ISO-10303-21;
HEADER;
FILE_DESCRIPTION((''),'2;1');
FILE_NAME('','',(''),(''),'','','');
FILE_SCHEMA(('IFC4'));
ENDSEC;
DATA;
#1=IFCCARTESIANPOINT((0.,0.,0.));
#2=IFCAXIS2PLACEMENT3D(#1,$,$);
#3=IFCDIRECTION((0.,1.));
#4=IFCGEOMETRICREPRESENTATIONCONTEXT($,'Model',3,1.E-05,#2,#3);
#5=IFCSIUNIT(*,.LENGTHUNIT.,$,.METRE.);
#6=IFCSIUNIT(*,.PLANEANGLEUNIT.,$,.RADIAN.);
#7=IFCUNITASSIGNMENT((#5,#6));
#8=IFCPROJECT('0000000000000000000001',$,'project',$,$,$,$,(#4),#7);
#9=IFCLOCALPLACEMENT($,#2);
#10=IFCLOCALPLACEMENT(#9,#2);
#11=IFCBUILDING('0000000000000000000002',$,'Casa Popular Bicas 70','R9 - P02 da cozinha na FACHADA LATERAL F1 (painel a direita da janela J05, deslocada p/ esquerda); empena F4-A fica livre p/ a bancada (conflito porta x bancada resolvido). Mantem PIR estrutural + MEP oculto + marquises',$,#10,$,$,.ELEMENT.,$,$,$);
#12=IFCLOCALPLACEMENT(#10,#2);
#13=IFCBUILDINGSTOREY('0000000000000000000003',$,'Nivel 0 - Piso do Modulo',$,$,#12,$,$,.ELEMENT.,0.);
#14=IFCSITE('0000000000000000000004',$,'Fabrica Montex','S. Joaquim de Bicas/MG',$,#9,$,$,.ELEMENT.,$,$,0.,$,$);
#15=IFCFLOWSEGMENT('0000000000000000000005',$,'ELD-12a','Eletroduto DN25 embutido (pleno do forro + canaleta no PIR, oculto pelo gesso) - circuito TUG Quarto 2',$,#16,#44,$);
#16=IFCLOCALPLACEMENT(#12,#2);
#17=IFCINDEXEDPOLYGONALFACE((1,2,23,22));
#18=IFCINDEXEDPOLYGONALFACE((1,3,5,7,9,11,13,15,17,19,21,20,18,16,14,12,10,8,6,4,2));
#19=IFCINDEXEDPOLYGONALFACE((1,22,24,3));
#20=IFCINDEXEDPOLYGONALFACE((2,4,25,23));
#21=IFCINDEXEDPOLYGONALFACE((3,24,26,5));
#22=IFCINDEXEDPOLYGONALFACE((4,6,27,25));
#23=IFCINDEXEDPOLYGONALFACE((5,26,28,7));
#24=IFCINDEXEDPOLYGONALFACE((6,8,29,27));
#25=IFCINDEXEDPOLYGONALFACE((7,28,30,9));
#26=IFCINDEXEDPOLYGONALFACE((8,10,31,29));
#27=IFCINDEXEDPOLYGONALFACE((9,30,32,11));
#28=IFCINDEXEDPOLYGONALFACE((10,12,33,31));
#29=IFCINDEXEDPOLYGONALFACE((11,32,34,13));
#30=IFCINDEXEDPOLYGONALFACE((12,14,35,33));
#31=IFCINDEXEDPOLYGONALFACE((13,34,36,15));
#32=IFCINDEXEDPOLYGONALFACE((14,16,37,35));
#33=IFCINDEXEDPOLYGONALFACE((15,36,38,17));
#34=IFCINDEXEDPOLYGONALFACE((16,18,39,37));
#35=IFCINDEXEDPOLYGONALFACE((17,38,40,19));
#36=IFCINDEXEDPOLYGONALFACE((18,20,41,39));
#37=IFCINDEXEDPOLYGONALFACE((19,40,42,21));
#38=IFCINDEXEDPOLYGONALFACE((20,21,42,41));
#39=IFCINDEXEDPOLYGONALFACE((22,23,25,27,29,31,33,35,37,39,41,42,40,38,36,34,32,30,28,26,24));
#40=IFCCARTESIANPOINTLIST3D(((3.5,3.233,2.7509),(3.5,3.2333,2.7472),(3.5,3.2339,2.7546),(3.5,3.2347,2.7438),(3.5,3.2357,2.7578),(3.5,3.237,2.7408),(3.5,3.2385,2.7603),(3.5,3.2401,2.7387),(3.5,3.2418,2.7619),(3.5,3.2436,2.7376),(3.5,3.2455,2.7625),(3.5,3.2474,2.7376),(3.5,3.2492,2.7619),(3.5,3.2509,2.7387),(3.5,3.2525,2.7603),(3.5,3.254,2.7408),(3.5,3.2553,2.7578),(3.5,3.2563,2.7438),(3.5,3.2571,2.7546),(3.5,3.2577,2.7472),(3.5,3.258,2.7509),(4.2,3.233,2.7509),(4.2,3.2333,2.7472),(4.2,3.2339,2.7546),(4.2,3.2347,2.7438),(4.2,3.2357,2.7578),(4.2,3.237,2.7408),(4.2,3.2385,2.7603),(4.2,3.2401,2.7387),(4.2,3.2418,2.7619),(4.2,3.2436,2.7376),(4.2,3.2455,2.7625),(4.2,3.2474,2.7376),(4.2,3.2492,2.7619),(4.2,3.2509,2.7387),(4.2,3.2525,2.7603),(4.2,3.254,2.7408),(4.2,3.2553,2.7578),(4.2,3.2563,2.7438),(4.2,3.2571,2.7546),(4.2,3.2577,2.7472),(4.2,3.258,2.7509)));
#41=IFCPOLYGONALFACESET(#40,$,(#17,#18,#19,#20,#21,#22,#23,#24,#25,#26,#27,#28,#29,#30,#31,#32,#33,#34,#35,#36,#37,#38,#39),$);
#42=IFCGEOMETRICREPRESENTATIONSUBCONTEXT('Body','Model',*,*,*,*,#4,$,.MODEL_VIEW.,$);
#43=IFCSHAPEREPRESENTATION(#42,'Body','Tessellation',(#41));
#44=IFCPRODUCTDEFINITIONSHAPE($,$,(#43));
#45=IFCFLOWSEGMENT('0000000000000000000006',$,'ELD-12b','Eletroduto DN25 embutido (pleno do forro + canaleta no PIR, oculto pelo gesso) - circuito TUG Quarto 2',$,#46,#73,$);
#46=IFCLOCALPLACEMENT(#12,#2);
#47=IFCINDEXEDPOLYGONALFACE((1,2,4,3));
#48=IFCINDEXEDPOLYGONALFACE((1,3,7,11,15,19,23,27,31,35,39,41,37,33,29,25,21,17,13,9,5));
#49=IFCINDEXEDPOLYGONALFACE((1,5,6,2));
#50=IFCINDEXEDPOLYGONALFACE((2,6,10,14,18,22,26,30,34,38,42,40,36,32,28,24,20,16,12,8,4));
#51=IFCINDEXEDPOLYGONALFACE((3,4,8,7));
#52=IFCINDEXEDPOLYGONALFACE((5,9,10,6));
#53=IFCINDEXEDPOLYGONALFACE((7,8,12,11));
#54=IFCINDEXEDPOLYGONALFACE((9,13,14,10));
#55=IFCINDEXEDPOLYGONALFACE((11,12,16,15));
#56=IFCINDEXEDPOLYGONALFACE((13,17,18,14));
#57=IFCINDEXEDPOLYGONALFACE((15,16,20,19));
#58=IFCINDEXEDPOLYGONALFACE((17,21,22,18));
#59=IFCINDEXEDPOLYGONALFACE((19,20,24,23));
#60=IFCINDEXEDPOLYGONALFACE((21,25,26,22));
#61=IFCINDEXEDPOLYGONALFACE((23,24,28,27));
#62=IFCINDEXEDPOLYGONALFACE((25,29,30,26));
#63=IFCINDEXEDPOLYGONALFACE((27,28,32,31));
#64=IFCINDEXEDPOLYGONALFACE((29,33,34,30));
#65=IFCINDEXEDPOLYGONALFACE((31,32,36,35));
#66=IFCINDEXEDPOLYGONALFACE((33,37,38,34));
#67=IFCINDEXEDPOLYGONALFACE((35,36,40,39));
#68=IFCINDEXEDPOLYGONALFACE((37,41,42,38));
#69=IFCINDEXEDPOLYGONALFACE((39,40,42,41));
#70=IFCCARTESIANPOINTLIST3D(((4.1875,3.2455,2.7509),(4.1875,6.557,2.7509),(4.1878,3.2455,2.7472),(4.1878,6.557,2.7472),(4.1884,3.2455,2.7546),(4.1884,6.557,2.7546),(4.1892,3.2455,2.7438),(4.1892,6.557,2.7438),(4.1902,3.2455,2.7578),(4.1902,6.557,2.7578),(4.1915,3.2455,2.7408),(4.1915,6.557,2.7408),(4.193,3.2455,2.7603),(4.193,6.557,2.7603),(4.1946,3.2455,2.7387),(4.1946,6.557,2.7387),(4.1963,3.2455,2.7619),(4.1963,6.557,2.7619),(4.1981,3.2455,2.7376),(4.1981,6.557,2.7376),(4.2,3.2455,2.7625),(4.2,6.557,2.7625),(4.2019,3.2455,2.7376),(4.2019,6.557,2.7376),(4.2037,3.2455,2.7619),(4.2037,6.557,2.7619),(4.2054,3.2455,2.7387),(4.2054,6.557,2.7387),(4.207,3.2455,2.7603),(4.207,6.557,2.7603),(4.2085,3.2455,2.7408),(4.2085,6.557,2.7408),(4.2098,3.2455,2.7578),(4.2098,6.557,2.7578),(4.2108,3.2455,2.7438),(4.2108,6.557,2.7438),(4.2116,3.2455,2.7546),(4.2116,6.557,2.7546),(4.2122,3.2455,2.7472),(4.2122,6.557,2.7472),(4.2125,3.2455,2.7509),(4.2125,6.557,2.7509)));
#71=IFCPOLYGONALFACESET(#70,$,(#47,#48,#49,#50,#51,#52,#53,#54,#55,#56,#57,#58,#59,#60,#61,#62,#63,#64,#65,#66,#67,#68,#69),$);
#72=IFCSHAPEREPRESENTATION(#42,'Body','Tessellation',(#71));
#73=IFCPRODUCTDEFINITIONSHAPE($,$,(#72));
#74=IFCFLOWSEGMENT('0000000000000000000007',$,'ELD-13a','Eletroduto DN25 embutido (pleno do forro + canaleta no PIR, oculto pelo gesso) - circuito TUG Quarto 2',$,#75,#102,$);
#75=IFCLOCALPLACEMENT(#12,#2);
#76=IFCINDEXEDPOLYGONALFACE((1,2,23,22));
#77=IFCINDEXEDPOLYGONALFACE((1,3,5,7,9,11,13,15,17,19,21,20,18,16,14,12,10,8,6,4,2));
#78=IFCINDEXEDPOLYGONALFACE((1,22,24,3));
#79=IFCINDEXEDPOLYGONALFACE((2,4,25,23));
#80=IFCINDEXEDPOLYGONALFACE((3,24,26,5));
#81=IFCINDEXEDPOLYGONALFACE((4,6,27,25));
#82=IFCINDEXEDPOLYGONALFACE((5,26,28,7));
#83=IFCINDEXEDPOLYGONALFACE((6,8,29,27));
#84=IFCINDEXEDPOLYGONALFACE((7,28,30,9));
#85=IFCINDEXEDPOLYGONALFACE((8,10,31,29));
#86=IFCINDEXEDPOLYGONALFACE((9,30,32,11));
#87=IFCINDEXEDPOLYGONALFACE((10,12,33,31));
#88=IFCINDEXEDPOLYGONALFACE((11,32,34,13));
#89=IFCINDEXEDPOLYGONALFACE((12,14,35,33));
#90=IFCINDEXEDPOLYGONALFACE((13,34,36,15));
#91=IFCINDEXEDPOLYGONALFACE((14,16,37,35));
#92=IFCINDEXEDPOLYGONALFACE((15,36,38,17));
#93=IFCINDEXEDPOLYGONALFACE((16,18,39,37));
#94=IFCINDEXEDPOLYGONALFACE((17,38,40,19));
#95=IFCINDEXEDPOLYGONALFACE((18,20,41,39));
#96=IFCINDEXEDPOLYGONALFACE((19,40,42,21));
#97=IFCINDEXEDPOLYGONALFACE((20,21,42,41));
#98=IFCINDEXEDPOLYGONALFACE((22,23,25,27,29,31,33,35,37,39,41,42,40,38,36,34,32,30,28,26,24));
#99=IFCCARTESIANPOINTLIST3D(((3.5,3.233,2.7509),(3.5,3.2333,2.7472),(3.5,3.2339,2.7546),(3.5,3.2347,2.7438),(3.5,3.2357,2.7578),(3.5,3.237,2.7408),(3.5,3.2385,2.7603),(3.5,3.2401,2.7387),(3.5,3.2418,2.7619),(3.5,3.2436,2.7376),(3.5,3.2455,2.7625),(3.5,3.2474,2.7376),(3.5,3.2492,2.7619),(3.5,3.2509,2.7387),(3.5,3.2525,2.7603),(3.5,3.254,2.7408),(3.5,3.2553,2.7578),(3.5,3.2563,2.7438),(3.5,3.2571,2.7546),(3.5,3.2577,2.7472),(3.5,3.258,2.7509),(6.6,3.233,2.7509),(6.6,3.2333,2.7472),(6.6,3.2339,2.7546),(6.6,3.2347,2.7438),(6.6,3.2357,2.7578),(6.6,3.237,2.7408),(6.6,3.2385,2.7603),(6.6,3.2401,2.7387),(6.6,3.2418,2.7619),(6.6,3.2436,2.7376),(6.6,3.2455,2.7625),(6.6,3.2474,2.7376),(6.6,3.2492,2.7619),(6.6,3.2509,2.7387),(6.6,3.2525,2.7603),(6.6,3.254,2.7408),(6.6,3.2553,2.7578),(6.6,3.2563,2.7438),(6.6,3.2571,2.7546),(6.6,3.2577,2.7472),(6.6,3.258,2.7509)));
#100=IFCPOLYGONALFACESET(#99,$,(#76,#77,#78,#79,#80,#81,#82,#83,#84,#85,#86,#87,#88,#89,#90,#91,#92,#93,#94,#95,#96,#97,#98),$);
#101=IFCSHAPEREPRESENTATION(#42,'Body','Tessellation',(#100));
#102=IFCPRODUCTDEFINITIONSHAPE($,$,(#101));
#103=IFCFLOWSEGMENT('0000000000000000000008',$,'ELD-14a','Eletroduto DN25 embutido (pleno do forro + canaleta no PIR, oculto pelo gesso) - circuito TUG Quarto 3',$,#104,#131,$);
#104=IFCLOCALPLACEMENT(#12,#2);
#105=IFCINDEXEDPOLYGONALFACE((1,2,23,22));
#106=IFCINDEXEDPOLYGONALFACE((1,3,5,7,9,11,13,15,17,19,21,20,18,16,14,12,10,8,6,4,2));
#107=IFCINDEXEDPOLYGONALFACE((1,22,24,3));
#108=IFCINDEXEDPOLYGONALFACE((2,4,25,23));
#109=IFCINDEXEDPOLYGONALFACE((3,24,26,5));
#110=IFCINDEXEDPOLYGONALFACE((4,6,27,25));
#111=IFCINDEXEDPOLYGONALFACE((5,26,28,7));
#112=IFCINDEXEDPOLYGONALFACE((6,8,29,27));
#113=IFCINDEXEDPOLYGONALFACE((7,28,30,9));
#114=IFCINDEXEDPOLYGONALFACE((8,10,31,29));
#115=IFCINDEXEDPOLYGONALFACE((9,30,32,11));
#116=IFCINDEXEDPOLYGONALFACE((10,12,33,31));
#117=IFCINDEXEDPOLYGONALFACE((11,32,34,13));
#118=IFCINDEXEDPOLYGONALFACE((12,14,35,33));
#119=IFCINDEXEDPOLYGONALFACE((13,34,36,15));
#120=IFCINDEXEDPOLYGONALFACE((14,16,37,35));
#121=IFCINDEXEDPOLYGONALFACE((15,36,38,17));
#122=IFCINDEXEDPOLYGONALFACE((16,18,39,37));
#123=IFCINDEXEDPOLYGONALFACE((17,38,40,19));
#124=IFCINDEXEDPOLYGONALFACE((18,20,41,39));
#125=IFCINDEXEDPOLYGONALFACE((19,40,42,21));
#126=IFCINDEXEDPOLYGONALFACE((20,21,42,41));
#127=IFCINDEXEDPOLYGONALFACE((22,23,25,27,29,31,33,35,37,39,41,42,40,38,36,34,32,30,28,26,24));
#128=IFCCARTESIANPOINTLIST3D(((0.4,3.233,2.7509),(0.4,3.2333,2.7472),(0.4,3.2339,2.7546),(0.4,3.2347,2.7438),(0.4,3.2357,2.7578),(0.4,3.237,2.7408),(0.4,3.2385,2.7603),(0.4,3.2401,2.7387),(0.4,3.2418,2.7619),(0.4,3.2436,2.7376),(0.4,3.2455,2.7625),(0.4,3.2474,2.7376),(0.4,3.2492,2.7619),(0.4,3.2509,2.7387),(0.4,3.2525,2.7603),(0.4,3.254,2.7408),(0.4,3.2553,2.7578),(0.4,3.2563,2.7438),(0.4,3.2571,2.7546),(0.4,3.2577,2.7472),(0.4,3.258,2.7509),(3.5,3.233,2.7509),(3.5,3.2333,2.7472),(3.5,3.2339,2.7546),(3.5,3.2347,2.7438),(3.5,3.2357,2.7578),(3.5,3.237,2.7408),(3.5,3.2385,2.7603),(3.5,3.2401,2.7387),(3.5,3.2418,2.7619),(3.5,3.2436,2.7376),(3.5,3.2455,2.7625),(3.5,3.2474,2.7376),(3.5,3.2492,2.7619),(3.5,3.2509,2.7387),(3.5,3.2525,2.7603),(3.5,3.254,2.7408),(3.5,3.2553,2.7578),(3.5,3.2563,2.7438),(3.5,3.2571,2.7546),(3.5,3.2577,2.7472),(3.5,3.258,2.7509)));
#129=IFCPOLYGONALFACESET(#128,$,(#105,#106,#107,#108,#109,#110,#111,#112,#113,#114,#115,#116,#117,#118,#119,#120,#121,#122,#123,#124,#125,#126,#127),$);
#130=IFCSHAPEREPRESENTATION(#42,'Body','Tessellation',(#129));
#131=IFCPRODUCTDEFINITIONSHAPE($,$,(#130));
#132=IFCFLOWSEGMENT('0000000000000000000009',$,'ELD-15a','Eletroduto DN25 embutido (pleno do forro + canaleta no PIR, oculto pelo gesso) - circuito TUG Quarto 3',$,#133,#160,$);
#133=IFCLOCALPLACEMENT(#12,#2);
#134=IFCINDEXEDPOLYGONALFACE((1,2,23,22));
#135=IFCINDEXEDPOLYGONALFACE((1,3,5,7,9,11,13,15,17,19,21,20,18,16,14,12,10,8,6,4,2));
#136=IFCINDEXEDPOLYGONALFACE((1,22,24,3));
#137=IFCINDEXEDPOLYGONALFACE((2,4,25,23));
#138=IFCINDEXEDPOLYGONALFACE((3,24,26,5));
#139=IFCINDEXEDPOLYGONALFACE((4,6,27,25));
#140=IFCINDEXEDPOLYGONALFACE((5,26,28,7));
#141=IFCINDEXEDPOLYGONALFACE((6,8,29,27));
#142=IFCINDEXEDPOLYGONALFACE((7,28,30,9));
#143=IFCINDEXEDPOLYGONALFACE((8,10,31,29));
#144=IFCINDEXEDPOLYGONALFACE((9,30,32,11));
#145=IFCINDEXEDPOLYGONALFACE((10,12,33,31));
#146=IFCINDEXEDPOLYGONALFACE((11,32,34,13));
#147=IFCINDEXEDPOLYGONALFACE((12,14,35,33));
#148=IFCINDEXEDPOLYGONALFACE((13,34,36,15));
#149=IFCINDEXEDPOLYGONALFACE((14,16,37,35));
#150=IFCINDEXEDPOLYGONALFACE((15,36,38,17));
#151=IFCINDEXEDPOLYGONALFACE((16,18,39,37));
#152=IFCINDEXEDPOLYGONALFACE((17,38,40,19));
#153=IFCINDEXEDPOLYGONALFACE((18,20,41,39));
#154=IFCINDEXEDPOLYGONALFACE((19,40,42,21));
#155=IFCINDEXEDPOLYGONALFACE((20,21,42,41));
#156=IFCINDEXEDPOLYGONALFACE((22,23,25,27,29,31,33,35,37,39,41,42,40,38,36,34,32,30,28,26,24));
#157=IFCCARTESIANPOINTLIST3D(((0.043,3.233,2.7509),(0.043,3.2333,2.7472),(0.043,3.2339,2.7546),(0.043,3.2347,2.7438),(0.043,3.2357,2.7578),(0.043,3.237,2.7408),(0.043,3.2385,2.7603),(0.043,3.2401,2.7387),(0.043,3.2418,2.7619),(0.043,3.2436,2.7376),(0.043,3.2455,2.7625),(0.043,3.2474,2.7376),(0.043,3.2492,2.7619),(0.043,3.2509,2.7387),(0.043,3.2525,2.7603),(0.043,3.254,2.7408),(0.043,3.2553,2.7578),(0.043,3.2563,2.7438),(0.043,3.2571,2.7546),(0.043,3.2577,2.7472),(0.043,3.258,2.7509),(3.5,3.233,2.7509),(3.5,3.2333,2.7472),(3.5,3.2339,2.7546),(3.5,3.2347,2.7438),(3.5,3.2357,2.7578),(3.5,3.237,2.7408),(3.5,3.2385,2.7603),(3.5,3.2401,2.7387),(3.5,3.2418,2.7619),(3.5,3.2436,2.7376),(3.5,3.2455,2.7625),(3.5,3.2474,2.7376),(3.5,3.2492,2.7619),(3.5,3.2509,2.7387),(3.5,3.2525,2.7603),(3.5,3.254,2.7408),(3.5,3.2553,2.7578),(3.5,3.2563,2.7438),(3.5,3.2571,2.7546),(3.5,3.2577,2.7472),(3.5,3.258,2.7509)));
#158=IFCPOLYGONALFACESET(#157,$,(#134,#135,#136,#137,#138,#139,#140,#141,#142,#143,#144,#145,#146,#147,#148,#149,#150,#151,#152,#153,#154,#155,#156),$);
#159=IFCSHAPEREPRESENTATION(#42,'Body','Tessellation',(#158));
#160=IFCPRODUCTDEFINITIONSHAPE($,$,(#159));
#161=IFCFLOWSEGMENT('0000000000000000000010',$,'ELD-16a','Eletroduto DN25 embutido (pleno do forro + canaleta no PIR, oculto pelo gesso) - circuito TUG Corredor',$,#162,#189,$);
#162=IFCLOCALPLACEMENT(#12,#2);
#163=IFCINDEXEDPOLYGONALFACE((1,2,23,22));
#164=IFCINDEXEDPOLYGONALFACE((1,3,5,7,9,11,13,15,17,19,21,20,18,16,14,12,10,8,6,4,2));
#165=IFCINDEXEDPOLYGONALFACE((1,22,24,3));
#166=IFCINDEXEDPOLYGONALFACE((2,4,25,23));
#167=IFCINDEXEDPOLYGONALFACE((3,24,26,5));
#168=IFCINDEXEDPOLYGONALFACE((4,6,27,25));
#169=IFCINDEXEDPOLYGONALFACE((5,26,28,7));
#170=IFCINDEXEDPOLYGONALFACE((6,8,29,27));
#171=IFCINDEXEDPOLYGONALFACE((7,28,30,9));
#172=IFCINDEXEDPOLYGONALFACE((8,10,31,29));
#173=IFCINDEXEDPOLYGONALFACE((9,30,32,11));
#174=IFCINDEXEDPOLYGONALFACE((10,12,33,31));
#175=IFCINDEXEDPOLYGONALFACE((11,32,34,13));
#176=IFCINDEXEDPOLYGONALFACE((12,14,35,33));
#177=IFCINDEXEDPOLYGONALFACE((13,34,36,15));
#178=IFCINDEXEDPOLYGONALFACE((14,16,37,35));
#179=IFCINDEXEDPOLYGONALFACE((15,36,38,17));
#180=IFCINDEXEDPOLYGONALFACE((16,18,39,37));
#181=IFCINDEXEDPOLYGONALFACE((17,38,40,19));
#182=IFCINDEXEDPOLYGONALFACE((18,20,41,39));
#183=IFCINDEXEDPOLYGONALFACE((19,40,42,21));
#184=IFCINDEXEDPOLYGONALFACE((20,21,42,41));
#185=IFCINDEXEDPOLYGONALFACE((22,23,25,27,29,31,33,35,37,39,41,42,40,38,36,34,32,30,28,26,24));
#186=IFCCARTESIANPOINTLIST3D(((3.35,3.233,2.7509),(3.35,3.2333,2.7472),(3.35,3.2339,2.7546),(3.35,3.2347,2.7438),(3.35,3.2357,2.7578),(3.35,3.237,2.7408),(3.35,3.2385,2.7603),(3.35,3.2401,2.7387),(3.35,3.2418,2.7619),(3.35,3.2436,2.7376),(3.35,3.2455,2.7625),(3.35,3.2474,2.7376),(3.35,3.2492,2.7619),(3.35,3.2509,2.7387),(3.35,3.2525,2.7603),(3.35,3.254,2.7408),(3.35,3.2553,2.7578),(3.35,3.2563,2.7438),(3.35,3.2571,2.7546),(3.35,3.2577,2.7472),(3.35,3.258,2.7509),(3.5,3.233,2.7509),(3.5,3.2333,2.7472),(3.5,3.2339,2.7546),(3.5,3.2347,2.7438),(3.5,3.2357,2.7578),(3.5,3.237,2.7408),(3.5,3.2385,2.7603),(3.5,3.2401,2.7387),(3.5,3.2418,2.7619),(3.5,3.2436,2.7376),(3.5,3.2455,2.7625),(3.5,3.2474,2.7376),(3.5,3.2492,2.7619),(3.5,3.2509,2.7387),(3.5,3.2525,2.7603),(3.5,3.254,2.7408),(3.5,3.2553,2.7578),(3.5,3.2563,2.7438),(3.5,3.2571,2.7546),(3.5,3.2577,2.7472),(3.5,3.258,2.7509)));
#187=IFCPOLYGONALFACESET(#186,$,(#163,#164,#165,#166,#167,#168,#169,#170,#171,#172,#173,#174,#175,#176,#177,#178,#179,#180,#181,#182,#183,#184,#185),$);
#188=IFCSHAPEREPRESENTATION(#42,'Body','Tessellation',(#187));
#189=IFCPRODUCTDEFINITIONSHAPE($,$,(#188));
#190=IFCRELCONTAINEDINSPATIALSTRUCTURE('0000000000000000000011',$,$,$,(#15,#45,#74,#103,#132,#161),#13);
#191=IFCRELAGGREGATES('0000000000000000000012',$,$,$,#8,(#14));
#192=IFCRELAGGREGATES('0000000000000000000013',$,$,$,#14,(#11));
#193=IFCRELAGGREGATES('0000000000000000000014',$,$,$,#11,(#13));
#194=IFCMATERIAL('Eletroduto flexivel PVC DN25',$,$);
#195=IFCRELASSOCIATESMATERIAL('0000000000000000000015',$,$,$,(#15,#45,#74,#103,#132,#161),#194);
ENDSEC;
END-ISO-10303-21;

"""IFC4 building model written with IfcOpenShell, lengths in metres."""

from ifc_helpers import new_model, si_unit, direction, frame, origin, origin_2d, place, context, subcontext, project, spatial, circle, extrude, material, element, save


model = new_model("IFC4")

# Units and contexts
model_context = context("Model", 3, precision=1e-05, world=origin(), true_north=direction((0.0, 1.0)))
body_context = subcontext(model_context, "Body", "Model", "MODEL_VIEW")
ifc_project = project(units=[si_unit("LENGTHUNIT", "METRE"), si_unit("PLANEANGLEUNIT", "RADIAN")], contexts=[model_context])

# Site, building, storey
site_placement = place(None, origin())
site = spatial("IfcSite", under=ifc_project, at=site_placement, Name="Fabrica Montex", Description="S. Joaquim de Bicas/MG", CompositionType="ELEMENT", RefElevation=0.0)
building_placement = place(site_placement, origin())
building = spatial("IfcBuilding", under=site, at=building_placement, Name="Casa Popular Bicas 70", Description="R9 - P02 da cozinha na FACHADA LATERAL F1 (painel a direita da janela J05, deslocada p/ esquerda); empena F4-A fica livre p/ a bancada (conflito porta x bancada resolvido). Mantem PIR estrutural + MEP oculto + marquises", CompositionType="ELEMENT")
storey_placement = place(building_placement, origin())
storey = spatial("IfcBuildingStorey", under=building, at=storey_placement, Name="Nivel 0 - Piso do Modulo", CompositionType="ELEMENT", Elevation=0.0)

# Flow segments
ifc_material_1 = material(Name="Eletroduto flexivel PVC DN25")
flow_segment_1_placement = place(storey_placement, frame((3.5, 3.2455, 2.75), z_axis=(1.0, 0.0, 0.0), x_axis=(0.0, 0.0, 1.0)))
element("IfcFlowSegment", 1, at=flow_segment_1_placement, inside=storey, material=ifc_material_1, Name="ELD-12a", Description="Eletroduto DN25 embutido (pleno do forro + canaleta no PIR, oculto pelo gesso) - circuito TUG Quarto 2", context=body_context, shape_type="SweptSolid", body=[
    extrude(circle(Radius=0.0125, at=origin_2d()), origin(), (0.0, 0.0, 1.0), 0.7),
])
flow_segment_2_placement = place(storey_placement, frame((4.2, 3.2455, 2.75), z_axis=(0.0, 1.0, 0.0), x_axis=(0.0, 0.0, 1.0)))
element("IfcFlowSegment", 2, at=flow_segment_2_placement, inside=storey, material=ifc_material_1, Name="ELD-12b", Description="Eletroduto DN25 embutido (pleno do forro + canaleta no PIR, oculto pelo gesso) - circuito TUG Quarto 2", context=body_context, shape_type="SweptSolid", body=[
    extrude(circle(Radius=0.0125, at=origin_2d()), origin(), (0.0, 0.0, 1.0), 3.3115),
])
flow_segment_3_placement = place(storey_placement, frame((3.5, 3.2455, 2.75), z_axis=(1.0, 0.0, 0.0), x_axis=(0.0, 0.0, 1.0)))
element("IfcFlowSegment", 3, at=flow_segment_3_placement, inside=storey, material=ifc_material_1, Name="ELD-13a", Description="Eletroduto DN25 embutido (pleno do forro + canaleta no PIR, oculto pelo gesso) - circuito TUG Quarto 2", context=body_context, shape_type="SweptSolid", body=[
    extrude(circle(Radius=0.0125, at=origin_2d()), origin(), (0.0, 0.0, 1.0), 3.1),
])
flow_segment_4_placement = place(storey_placement, frame((3.5, 3.2455, 2.75), z_axis=(-1.0, 0.0, 0.0), x_axis=(0.0, 0.0, 1.0)))
element("IfcFlowSegment", 4, at=flow_segment_4_placement, inside=storey, material=ifc_material_1, Name="ELD-14a", Description="Eletroduto DN25 embutido (pleno do forro + canaleta no PIR, oculto pelo gesso) - circuito TUG Quarto 3", context=body_context, shape_type="SweptSolid", body=[
    extrude(circle(Radius=0.0125, at=origin_2d()), origin(), (0.0, 0.0, 1.0), 3.1),
])
flow_segment_5_placement = place(storey_placement, frame((3.5, 3.2455, 2.75), z_axis=(-1.0, 0.0, 0.0), x_axis=(0.0, 0.0, 1.0)))
element("IfcFlowSegment", 5, at=flow_segment_5_placement, inside=storey, material=ifc_material_1, Name="ELD-15a", Description="Eletroduto DN25 embutido (pleno do forro + canaleta no PIR, oculto pelo gesso) - circuito TUG Quarto 3", context=body_context, shape_type="SweptSolid", body=[
    extrude(circle(Radius=0.0125, at=origin_2d()), origin(), (0.0, 0.0, 1.0), 3.457),
])
flow_segment_6_placement = place(storey_placement, frame((3.5, 3.2455, 2.75), z_axis=(-1.0, 0.0, 0.0), x_axis=(0.0, 0.0, 1.0)))
element("IfcFlowSegment", 6, at=flow_segment_6_placement, inside=storey, material=ifc_material_1, Name="ELD-16a", Description="Eletroduto DN25 embutido (pleno do forro + canaleta no PIR, oculto pelo gesso) - circuito TUG Corredor", context=body_context, shape_type="SweptSolid", body=[
    extrude(circle(Radius=0.0125, at=origin_2d()), origin(), (0.0, 0.0, 1.0), 0.15),
])

save(model, "model.ifc")
